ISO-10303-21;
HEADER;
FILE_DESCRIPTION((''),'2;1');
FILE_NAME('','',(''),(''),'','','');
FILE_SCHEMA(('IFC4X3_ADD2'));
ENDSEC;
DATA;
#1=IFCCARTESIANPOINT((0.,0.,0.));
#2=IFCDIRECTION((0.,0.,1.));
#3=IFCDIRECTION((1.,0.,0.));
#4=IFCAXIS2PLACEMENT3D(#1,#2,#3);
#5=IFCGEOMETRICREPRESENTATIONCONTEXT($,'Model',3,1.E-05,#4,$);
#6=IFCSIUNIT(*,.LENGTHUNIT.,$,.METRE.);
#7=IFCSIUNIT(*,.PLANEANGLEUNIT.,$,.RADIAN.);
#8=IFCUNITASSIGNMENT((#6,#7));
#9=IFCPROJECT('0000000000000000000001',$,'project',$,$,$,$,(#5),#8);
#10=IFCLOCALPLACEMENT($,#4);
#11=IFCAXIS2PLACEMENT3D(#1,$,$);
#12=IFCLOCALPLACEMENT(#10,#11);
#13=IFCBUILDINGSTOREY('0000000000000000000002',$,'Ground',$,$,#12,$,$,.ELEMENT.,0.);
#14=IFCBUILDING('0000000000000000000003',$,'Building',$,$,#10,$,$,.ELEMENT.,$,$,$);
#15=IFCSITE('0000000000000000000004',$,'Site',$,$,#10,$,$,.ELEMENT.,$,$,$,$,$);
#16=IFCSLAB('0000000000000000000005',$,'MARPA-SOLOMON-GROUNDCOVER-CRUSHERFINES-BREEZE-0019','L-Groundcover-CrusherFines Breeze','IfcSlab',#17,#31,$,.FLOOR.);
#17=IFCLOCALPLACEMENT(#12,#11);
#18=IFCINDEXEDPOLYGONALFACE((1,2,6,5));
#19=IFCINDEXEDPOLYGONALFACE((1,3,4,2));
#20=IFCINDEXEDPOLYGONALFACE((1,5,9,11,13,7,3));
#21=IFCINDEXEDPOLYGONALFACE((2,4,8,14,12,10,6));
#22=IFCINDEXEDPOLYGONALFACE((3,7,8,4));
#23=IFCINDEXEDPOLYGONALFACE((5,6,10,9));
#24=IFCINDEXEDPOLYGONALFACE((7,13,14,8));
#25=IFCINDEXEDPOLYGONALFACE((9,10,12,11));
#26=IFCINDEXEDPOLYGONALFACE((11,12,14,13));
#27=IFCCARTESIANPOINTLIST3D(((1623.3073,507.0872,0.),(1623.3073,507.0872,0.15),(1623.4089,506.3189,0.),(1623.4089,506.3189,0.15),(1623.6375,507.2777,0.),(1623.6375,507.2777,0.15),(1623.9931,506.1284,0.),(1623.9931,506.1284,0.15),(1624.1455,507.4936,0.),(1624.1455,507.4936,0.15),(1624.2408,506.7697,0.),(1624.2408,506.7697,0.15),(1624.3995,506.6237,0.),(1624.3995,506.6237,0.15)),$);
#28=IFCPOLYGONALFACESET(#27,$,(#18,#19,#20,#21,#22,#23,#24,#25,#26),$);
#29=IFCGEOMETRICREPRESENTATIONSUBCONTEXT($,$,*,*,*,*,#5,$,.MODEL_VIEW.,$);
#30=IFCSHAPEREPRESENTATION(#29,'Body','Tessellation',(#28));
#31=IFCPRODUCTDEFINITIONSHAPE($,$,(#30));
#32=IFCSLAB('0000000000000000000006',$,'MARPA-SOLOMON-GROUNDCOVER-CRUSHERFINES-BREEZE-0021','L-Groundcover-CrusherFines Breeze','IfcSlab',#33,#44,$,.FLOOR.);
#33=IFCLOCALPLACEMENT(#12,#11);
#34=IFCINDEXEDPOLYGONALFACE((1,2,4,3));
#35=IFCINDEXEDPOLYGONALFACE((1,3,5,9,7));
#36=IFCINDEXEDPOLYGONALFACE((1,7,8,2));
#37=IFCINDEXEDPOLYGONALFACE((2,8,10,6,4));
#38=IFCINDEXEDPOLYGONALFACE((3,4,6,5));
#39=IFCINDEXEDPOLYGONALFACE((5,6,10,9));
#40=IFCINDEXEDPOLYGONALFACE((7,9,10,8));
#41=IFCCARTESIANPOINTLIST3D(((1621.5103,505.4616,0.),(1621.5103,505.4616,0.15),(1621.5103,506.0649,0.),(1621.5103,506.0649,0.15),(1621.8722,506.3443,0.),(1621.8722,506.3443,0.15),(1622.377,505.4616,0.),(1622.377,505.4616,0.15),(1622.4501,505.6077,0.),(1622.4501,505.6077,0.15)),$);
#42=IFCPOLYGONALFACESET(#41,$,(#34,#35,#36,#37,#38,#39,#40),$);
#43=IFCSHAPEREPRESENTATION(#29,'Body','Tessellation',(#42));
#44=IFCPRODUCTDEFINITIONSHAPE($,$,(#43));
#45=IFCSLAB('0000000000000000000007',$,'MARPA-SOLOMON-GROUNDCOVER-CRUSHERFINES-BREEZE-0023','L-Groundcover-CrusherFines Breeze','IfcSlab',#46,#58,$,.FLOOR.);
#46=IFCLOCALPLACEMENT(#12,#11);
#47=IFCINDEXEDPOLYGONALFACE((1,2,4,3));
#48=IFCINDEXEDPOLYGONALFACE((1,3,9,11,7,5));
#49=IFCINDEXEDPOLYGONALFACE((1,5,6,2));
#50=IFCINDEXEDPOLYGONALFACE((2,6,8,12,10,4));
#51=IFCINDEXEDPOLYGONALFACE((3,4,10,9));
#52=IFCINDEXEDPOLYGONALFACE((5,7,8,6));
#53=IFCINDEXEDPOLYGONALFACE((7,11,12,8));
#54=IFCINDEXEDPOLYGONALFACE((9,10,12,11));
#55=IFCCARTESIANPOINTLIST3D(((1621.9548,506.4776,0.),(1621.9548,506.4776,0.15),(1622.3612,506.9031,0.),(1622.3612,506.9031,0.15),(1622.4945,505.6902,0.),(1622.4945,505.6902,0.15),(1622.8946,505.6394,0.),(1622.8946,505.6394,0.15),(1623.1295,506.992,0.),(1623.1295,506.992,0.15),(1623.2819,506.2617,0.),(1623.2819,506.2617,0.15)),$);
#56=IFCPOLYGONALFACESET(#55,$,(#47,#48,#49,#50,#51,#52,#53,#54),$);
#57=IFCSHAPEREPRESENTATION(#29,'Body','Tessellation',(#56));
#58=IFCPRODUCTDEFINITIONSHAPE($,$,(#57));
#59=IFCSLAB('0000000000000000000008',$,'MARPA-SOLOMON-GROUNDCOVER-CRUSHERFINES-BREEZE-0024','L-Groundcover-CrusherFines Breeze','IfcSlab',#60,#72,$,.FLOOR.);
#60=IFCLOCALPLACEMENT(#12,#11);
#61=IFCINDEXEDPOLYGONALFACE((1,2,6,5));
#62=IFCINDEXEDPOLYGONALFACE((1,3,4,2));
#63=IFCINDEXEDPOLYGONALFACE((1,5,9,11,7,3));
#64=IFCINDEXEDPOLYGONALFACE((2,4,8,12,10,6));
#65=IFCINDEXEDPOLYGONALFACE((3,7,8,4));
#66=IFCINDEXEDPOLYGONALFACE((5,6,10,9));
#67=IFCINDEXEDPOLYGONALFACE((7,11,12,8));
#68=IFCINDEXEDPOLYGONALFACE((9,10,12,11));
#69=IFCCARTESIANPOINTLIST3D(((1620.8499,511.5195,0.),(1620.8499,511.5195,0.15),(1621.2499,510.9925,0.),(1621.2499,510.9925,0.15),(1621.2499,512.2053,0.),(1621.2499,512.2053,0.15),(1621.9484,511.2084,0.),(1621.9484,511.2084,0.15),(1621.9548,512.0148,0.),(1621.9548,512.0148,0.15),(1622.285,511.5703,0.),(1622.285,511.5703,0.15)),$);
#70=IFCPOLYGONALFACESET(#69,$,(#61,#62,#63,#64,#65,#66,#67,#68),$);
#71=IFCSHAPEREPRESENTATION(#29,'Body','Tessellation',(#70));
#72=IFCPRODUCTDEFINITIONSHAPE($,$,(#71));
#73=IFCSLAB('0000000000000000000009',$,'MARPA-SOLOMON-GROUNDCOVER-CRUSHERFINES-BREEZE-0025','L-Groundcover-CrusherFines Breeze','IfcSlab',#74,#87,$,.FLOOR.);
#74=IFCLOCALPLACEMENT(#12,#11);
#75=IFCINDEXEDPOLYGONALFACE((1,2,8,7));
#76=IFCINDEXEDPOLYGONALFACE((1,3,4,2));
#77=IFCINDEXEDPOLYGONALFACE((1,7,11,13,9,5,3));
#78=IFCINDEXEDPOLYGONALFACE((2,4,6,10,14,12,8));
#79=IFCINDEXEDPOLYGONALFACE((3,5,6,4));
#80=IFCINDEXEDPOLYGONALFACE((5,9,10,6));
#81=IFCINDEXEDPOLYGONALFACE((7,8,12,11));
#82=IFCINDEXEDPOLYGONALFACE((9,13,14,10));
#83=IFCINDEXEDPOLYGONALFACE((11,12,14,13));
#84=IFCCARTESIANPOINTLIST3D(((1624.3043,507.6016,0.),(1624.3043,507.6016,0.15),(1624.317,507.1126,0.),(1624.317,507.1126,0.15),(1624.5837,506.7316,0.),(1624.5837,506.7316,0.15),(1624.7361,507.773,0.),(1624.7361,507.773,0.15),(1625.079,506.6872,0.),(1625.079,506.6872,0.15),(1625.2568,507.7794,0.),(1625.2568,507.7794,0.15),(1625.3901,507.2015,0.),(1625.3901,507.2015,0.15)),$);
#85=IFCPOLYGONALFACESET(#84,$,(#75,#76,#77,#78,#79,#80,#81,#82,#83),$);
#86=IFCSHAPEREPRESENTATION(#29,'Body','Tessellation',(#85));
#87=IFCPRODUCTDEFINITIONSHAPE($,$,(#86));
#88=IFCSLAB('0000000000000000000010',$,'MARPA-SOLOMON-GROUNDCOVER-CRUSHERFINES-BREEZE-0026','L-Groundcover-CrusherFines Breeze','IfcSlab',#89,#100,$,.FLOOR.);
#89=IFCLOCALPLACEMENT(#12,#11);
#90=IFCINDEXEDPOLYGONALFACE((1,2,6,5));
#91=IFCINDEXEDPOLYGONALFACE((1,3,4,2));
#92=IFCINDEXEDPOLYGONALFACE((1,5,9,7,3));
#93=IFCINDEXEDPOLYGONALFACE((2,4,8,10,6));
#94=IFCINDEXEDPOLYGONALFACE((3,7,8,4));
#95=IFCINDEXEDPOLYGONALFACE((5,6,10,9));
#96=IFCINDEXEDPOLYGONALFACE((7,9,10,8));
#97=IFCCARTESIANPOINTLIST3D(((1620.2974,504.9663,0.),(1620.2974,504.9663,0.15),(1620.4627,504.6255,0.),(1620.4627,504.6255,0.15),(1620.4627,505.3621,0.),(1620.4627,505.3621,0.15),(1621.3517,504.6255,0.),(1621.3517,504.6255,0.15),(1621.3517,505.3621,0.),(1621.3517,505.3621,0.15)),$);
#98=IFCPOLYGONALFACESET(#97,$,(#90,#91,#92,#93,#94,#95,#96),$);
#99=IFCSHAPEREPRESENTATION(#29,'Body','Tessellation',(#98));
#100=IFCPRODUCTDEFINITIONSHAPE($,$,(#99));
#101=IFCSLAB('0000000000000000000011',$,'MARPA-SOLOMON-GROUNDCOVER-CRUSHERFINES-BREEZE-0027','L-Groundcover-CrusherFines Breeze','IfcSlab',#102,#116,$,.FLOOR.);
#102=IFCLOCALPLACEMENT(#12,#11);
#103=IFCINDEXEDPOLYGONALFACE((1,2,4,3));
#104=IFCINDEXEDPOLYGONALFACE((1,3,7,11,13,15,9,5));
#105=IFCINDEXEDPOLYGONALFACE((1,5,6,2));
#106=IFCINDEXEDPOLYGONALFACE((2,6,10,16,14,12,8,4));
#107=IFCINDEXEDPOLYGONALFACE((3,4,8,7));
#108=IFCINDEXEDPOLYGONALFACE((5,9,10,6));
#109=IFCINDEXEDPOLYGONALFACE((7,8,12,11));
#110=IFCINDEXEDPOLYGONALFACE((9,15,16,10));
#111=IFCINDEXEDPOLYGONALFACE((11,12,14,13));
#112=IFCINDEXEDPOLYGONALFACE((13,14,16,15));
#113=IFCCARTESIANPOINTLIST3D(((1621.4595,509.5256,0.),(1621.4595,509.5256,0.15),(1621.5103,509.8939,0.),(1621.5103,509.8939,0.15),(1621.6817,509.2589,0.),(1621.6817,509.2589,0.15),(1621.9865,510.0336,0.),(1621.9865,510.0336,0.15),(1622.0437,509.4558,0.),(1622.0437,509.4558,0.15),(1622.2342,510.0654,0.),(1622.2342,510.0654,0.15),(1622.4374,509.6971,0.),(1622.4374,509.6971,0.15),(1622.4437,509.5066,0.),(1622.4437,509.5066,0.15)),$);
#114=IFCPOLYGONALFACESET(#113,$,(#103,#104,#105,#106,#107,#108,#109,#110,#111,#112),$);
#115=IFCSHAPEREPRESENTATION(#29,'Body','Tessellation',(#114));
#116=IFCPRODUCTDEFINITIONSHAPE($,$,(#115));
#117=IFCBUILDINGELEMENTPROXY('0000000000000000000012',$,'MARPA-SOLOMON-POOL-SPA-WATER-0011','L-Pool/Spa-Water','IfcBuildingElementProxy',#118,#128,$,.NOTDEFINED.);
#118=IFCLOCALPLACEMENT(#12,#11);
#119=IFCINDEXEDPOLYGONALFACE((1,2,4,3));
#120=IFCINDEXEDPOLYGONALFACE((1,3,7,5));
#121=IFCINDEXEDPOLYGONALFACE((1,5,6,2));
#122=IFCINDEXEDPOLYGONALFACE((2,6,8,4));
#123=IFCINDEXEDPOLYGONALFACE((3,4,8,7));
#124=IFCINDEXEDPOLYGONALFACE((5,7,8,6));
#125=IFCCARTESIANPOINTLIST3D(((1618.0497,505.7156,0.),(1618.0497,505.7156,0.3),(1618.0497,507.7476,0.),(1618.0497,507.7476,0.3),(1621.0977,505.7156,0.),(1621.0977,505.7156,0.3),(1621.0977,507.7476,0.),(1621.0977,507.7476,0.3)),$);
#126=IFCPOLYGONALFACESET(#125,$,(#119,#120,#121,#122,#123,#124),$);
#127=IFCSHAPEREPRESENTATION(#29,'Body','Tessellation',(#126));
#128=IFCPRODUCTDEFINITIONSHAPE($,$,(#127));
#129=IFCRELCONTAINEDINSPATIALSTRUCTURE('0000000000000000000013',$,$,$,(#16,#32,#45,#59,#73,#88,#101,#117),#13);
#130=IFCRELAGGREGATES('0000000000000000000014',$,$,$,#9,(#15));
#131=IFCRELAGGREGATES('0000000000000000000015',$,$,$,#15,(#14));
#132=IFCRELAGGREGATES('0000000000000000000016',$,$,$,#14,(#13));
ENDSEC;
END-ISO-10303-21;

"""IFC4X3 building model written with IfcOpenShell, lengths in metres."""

from ifc_helpers import new_model, si_unit, frame, origin, origin_with_axes, place, context, subcontext, project, spatial, polyline, outline, extrude, element, save


model = new_model("IFC4X3")

# Units and contexts
model_context = context("Model", 3, precision=1e-05, world=origin_with_axes())
sub_context = subcontext(model_context, None, None, "MODEL_VIEW")
ifc_project = project(units=[si_unit("LENGTHUNIT", "METRE"), si_unit("PLANEANGLEUNIT", "RADIAN")], contexts=[model_context])

# Site, building, storey
placement = place(None, origin_with_axes())
site = spatial("IfcSite", under=ifc_project, at=placement, Name="Site", CompositionType="ELEMENT")
building = spatial("IfcBuilding", under=site, at=placement, Name="Building", CompositionType="ELEMENT")
storey_placement = place(placement, origin())
storey = spatial("IfcBuildingStorey", under=building, at=storey_placement, Name="Ground", CompositionType="ELEMENT", Elevation=0.0)

# Slabs
slab_1_placement = place(storey_placement, frame((1623.3073, 506.1284, 0.0)))
element("IfcSlab", 1, at=slab_1_placement, inside=storey, Name="MARPA-SOLOMON-GROUNDCOVER-CRUSHERFINES-BREEZE-0019", Description="L-Groundcover-CrusherFines Breeze", ObjectType="IfcSlab", PredefinedType="FLOOR", context=sub_context, shape_type="SweptSolid", body=[
    extrude(outline(polyline([(0.9335, 0.6413), (0.8382, 1.3653), (0.3302, 1.1494), (0.0, 0.9588), (0.1016, 0.1905), (0.6858, 0.0), (1.0922, 0.4953), (0.9335, 0.6413)])), origin(), (0.0, 0.0, 1.0), 0.15),
])
slab_2_placement = place(storey_placement, frame((1621.5103, 505.4616, 0.0)))
element("IfcSlab", 2, at=slab_2_placement, inside=storey, Name="MARPA-SOLOMON-GROUNDCOVER-CRUSHERFINES-BREEZE-0021", Description="L-Groundcover-CrusherFines Breeze", ObjectType="IfcSlab", PredefinedType="FLOOR", context=sub_context, shape_type="SweptSolid", body=[
    extrude(outline(polyline([(0.3619, 0.8826), (0.0, 0.6032), (0.0, 0.0), (0.8668, 0.0), (0.9398, 0.146), (0.3619, 0.8826)])), origin(), (0.0, 0.0, 1.0), 0.15),
])
slab_3_placement = place(storey_placement, frame((1621.9548, 505.6394, 0.0)))
element("IfcSlab", 3, at=slab_3_placement, inside=storey, Name="MARPA-SOLOMON-GROUNDCOVER-CRUSHERFINES-BREEZE-0023", Description="L-Groundcover-CrusherFines Breeze", ObjectType="IfcSlab", PredefinedType="FLOOR", context=sub_context, shape_type="SweptSolid", body=[
    extrude(outline(polyline([(1.1748, 1.3526), (1.3272, 0.6223), (0.9398, 0.0), (0.5398, 0.0508), (0.0, 0.8382), (0.4064, 1.2636), (1.1748, 1.3526)])), origin(), (0.0, 0.0, 1.0), 0.15),
])
slab_4_placement = place(storey_placement, frame((1620.8499, 510.9925, 0.0)))
element("IfcSlab", 4, at=slab_4_placement, inside=storey, Name="MARPA-SOLOMON-GROUNDCOVER-CRUSHERFINES-BREEZE-0024", Description="L-Groundcover-CrusherFines Breeze", ObjectType="IfcSlab", PredefinedType="FLOOR", context=sub_context, shape_type="SweptSolid", body=[
    extrude(outline(polyline([(0.0, 0.527), (0.4, 0.0), (1.0986, 0.2159), (1.4351, 0.5778), (1.1049, 1.0224), (0.4, 1.2128), (0.0, 0.527)])), origin(), (0.0, 0.0, 1.0), 0.15),
])
slab_5_placement = place(storey_placement, frame((1624.3043, 506.6872, 0.0)))
element("IfcSlab", 5, at=slab_5_placement, inside=storey, Name="MARPA-SOLOMON-GROUNDCOVER-CRUSHERFINES-BREEZE-0025", Description="L-Groundcover-CrusherFines Breeze", ObjectType="IfcSlab", PredefinedType="FLOOR", context=sub_context, shape_type="SweptSolid", body=[
    extrude(outline(polyline([(0.7747, 0.0), (1.0858, 0.5143), (0.9525, 1.0922), (0.4318, 1.0858), (0.0, 0.9144), (0.0127, 0.4255), (0.2794, 0.0444), (0.7747, 0.0)])), origin(), (0.0, 0.0, 1.0), 0.15),
])
slab_6_placement = place(storey_placement, frame((1620.2974, 504.6255, 0.0)))
element("IfcSlab", 6, at=slab_6_placement, inside=storey, Name="MARPA-SOLOMON-GROUNDCOVER-CRUSHERFINES-BREEZE-0026", Description="L-Groundcover-CrusherFines Breeze", ObjectType="IfcSlab", PredefinedType="FLOOR", context=sub_context, shape_type="SweptSolid", body=[
    extrude(outline(polyline([(1.0543, 0.7366), (1.0543, 0.0), (0.1653, 0.0), (0.0, 0.3409), (0.1653, 0.7366), (1.0543, 0.7366)])), origin(), (0.0, 0.0, 1.0), 0.15),
])
slab_7_placement = place(storey_placement, frame((1621.4595, 509.2589, 0.0)))
element("IfcSlab", 7, at=slab_7_placement, inside=storey, Name="MARPA-SOLOMON-GROUNDCOVER-CRUSHERFINES-BREEZE-0027", Description="L-Groundcover-CrusherFines Breeze", ObjectType="IfcSlab", PredefinedType="FLOOR", context=sub_context, shape_type="SweptSolid", body=[
    extrude(outline(polyline([(0.2223, 0.0), (0.0, 0.2667), (0.0508, 0.635), (0.5271, 0.7747), (0.7747, 0.8064), (0.9779, 0.4381), (0.9843, 0.2476), (0.5842, 0.1968), (0.2223, 0.0)])), origin(), (0.0, 0.0, 1.0), 0.15),
])

# Building element proxy
proxy_placement = place(placement, frame((1618.0497, 505.7156, 0.0)))
element("IfcBuildingElementProxy", 8, at=proxy_placement, inside=storey, Name="MARPA-SOLOMON-POOL-SPA-WATER-0011", Description="L-Pool/Spa-Water", ObjectType="IfcBuildingElementProxy", PredefinedType="NOTDEFINED", context=sub_context, shape_type="SweptSolid", body=[
    extrude(outline(polyline([(0.0, 2.032), (3.048, 2.032), (3.048, 0.0), (0.0, 0.0), (0.0, 2.032)])), origin(), (0.0, 0.0, 1.0), 0.3),
])

save(model, "model.ifc")
